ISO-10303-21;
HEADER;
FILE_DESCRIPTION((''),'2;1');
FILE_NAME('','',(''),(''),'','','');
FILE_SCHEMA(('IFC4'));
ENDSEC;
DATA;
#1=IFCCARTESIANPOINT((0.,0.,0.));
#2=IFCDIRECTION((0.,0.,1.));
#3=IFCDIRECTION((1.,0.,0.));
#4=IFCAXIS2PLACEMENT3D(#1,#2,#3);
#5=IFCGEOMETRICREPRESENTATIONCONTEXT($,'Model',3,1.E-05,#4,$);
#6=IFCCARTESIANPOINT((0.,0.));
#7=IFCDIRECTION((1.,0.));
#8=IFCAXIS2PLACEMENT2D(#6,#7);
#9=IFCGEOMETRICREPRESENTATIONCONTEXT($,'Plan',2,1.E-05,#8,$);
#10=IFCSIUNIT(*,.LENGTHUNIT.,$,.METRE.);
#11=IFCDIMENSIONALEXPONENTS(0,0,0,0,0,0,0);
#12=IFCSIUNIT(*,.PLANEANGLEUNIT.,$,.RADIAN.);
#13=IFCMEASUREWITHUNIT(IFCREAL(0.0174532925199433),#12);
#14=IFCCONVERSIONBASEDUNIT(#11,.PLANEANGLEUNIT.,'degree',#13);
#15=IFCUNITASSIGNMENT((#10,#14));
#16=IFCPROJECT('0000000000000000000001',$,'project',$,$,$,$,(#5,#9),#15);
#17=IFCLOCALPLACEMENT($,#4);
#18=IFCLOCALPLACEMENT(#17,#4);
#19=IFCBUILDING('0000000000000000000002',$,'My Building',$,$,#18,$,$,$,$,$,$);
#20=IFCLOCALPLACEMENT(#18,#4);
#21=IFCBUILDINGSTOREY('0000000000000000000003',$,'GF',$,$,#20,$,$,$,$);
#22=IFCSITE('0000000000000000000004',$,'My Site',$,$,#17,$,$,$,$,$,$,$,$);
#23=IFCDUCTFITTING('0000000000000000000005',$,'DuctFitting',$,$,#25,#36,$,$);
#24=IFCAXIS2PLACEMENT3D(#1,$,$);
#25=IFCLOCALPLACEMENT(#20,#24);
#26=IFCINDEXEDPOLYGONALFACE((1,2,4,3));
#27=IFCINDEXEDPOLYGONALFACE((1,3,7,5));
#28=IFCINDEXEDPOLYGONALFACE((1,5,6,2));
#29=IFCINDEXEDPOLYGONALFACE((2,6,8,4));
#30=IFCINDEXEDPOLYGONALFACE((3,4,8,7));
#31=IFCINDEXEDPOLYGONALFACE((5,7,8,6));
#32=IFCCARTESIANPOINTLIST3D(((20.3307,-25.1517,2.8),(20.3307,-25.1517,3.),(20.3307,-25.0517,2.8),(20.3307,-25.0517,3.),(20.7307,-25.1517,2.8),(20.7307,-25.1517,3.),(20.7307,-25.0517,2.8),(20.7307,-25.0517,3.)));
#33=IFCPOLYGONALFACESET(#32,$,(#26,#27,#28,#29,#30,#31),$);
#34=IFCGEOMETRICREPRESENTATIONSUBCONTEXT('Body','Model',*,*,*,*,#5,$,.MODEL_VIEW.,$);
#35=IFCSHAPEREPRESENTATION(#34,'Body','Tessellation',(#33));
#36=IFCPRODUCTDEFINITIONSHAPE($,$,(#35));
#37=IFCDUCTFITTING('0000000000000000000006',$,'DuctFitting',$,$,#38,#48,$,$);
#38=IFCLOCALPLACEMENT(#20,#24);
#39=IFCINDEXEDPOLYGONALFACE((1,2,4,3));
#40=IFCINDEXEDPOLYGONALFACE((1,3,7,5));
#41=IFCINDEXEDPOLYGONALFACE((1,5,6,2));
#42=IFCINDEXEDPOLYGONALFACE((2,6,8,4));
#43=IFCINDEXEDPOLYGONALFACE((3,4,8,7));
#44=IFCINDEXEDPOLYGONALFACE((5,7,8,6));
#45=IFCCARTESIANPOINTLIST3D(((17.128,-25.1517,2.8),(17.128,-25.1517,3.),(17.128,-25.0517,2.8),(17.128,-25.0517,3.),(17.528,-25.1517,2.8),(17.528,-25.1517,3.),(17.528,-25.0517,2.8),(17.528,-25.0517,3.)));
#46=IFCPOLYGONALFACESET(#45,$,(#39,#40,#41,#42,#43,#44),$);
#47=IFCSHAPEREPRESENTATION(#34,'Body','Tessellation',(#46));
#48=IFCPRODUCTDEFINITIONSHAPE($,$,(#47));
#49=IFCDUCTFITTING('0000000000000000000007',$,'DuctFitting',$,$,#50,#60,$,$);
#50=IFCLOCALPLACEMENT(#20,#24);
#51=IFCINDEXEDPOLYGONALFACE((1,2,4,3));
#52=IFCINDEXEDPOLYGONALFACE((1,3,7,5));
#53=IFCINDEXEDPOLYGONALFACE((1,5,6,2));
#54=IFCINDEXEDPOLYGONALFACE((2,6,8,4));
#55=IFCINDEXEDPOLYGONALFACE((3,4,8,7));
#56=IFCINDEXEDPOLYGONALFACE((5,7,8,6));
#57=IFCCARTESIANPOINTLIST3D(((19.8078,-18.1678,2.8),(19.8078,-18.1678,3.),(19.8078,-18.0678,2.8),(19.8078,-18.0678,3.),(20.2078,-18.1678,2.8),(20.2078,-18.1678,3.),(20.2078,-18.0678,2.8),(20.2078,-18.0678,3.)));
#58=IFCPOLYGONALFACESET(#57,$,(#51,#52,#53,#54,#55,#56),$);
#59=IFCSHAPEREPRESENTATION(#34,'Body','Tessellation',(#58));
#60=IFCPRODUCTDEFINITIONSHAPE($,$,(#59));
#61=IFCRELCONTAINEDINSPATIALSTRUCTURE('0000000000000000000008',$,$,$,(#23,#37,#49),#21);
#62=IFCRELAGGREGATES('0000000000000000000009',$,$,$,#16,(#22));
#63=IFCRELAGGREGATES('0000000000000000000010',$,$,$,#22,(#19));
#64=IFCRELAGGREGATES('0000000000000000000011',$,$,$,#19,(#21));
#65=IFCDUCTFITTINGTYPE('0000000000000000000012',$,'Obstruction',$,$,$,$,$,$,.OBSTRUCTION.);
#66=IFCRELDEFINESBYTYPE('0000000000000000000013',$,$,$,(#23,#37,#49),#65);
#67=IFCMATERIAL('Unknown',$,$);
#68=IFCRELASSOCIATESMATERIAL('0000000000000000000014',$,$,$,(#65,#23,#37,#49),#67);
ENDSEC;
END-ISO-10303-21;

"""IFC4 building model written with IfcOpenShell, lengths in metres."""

from ifc_helpers import new_model, entity, si_unit, converted_unit, frame, origin_with_axes, origin_2d_with_axis, place, context, subcontext, project, spatial, rectangle, extrude, material, material_profile, profile_set, profile_usage, type_object, element, save


model = new_model("IFC4")

# Units and contexts
model_context = context("Model", 3, precision=1e-05, world=origin_with_axes())
plan_context = context("Plan", 2, precision=1e-05, world=origin_2d_with_axis())
body_context_1 = subcontext(model_context, "Body", "Model", "MODEL_VIEW")
ifc_project = project(units=[si_unit("LENGTHUNIT", "METRE"), converted_unit("PLANEANGLEUNIT", "degree", entity("IfcReal", 0.0174532925199433), si_unit("PLANEANGLEUNIT", "RADIAN"), dimensions=[0, 0, 0, 0, 0, 0, 0])], contexts=[model_context, plan_context])

# Site, building, storey
site_placement = place(None, origin_with_axes())
site = spatial("IfcSite", under=ifc_project, at=site_placement, Name="My Site")
building_placement = place(site_placement, origin_with_axes())
building = spatial("IfcBuilding", under=site, at=building_placement, Name="My Building")
storey_placement = place(building_placement, origin_with_axes())
storey = spatial("IfcBuildingStorey", under=building, at=storey_placement, Name="GF")

# Shared definitions
ifc_material = material(Name="Unknown")

# Duct fittings
ifc_material_profile_1 = material_profile(ifc_material, rectangle(XDim=0.4, YDim=0.2))
ifc_profile_set_1 = profile_set([ifc_material_profile_1])
duct_fitting_type_1 = type_object("IfcDuctFittingType", Name="Obstruction", PredefinedType="OBSTRUCTION", material=ifc_profile_set_1)
ifc_profile_usage_1 = profile_usage(ifc_profile_set_1, cardinal=5)
duct_fitting_1_placement = place(storey_placement, frame((20.5307, -25.0517, 2.9), z_axis=(0.0, -1.0, 0.0), x_axis=(1.0, 0.0, 0.0)))
element("IfcDuctFitting", 1, at=duct_fitting_1_placement, inside=storey, type_object=duct_fitting_type_1, material=ifc_profile_usage_1, Name="DuctFitting", context=body_context_1, shape_type="SweptSolid", body=[
    extrude(rectangle(XDim=0.4, YDim=0.2), origin_with_axes(), (0.0, 0.0, 1.0), 0.1),
])
ifc_profile_usage_2 = profile_usage(ifc_profile_set_1, cardinal=5)
duct_fitting_2_placement = place(storey_placement, frame((17.328, -25.0517, 2.9), z_axis=(0.0, -1.0, 0.0), x_axis=(1.0, 0.0, 0.0)))
element("IfcDuctFitting", 2, at=duct_fitting_2_placement, inside=storey, type_object=duct_fitting_type_1, material=ifc_profile_usage_2, Name="DuctFitting", context=body_context_1, shape_type="SweptSolid", body=[
    extrude(rectangle(XDim=0.4, YDim=0.2), origin_with_axes(), (0.0, 0.0, 1.0), 0.1),
])
ifc_profile_usage_3 = profile_usage(ifc_profile_set_1, cardinal=5)
duct_fitting_3_placement = place(storey_placement, frame((20.0078, -18.0678, 2.9), z_axis=(0.0, -1.0, 0.0), x_axis=(1.0, 0.0, 0.0)))
element("IfcDuctFitting", 3, at=duct_fitting_3_placement, inside=storey, type_object=duct_fitting_type_1, material=ifc_profile_usage_3, Name="DuctFitting", context=body_context_1, shape_type="SweptSolid", body=[
    extrude(rectangle(XDim=0.4, YDim=0.2), origin_with_axes(), (0.0, 0.0, 1.0), 0.1),
])

save(model, "model.ifc")
